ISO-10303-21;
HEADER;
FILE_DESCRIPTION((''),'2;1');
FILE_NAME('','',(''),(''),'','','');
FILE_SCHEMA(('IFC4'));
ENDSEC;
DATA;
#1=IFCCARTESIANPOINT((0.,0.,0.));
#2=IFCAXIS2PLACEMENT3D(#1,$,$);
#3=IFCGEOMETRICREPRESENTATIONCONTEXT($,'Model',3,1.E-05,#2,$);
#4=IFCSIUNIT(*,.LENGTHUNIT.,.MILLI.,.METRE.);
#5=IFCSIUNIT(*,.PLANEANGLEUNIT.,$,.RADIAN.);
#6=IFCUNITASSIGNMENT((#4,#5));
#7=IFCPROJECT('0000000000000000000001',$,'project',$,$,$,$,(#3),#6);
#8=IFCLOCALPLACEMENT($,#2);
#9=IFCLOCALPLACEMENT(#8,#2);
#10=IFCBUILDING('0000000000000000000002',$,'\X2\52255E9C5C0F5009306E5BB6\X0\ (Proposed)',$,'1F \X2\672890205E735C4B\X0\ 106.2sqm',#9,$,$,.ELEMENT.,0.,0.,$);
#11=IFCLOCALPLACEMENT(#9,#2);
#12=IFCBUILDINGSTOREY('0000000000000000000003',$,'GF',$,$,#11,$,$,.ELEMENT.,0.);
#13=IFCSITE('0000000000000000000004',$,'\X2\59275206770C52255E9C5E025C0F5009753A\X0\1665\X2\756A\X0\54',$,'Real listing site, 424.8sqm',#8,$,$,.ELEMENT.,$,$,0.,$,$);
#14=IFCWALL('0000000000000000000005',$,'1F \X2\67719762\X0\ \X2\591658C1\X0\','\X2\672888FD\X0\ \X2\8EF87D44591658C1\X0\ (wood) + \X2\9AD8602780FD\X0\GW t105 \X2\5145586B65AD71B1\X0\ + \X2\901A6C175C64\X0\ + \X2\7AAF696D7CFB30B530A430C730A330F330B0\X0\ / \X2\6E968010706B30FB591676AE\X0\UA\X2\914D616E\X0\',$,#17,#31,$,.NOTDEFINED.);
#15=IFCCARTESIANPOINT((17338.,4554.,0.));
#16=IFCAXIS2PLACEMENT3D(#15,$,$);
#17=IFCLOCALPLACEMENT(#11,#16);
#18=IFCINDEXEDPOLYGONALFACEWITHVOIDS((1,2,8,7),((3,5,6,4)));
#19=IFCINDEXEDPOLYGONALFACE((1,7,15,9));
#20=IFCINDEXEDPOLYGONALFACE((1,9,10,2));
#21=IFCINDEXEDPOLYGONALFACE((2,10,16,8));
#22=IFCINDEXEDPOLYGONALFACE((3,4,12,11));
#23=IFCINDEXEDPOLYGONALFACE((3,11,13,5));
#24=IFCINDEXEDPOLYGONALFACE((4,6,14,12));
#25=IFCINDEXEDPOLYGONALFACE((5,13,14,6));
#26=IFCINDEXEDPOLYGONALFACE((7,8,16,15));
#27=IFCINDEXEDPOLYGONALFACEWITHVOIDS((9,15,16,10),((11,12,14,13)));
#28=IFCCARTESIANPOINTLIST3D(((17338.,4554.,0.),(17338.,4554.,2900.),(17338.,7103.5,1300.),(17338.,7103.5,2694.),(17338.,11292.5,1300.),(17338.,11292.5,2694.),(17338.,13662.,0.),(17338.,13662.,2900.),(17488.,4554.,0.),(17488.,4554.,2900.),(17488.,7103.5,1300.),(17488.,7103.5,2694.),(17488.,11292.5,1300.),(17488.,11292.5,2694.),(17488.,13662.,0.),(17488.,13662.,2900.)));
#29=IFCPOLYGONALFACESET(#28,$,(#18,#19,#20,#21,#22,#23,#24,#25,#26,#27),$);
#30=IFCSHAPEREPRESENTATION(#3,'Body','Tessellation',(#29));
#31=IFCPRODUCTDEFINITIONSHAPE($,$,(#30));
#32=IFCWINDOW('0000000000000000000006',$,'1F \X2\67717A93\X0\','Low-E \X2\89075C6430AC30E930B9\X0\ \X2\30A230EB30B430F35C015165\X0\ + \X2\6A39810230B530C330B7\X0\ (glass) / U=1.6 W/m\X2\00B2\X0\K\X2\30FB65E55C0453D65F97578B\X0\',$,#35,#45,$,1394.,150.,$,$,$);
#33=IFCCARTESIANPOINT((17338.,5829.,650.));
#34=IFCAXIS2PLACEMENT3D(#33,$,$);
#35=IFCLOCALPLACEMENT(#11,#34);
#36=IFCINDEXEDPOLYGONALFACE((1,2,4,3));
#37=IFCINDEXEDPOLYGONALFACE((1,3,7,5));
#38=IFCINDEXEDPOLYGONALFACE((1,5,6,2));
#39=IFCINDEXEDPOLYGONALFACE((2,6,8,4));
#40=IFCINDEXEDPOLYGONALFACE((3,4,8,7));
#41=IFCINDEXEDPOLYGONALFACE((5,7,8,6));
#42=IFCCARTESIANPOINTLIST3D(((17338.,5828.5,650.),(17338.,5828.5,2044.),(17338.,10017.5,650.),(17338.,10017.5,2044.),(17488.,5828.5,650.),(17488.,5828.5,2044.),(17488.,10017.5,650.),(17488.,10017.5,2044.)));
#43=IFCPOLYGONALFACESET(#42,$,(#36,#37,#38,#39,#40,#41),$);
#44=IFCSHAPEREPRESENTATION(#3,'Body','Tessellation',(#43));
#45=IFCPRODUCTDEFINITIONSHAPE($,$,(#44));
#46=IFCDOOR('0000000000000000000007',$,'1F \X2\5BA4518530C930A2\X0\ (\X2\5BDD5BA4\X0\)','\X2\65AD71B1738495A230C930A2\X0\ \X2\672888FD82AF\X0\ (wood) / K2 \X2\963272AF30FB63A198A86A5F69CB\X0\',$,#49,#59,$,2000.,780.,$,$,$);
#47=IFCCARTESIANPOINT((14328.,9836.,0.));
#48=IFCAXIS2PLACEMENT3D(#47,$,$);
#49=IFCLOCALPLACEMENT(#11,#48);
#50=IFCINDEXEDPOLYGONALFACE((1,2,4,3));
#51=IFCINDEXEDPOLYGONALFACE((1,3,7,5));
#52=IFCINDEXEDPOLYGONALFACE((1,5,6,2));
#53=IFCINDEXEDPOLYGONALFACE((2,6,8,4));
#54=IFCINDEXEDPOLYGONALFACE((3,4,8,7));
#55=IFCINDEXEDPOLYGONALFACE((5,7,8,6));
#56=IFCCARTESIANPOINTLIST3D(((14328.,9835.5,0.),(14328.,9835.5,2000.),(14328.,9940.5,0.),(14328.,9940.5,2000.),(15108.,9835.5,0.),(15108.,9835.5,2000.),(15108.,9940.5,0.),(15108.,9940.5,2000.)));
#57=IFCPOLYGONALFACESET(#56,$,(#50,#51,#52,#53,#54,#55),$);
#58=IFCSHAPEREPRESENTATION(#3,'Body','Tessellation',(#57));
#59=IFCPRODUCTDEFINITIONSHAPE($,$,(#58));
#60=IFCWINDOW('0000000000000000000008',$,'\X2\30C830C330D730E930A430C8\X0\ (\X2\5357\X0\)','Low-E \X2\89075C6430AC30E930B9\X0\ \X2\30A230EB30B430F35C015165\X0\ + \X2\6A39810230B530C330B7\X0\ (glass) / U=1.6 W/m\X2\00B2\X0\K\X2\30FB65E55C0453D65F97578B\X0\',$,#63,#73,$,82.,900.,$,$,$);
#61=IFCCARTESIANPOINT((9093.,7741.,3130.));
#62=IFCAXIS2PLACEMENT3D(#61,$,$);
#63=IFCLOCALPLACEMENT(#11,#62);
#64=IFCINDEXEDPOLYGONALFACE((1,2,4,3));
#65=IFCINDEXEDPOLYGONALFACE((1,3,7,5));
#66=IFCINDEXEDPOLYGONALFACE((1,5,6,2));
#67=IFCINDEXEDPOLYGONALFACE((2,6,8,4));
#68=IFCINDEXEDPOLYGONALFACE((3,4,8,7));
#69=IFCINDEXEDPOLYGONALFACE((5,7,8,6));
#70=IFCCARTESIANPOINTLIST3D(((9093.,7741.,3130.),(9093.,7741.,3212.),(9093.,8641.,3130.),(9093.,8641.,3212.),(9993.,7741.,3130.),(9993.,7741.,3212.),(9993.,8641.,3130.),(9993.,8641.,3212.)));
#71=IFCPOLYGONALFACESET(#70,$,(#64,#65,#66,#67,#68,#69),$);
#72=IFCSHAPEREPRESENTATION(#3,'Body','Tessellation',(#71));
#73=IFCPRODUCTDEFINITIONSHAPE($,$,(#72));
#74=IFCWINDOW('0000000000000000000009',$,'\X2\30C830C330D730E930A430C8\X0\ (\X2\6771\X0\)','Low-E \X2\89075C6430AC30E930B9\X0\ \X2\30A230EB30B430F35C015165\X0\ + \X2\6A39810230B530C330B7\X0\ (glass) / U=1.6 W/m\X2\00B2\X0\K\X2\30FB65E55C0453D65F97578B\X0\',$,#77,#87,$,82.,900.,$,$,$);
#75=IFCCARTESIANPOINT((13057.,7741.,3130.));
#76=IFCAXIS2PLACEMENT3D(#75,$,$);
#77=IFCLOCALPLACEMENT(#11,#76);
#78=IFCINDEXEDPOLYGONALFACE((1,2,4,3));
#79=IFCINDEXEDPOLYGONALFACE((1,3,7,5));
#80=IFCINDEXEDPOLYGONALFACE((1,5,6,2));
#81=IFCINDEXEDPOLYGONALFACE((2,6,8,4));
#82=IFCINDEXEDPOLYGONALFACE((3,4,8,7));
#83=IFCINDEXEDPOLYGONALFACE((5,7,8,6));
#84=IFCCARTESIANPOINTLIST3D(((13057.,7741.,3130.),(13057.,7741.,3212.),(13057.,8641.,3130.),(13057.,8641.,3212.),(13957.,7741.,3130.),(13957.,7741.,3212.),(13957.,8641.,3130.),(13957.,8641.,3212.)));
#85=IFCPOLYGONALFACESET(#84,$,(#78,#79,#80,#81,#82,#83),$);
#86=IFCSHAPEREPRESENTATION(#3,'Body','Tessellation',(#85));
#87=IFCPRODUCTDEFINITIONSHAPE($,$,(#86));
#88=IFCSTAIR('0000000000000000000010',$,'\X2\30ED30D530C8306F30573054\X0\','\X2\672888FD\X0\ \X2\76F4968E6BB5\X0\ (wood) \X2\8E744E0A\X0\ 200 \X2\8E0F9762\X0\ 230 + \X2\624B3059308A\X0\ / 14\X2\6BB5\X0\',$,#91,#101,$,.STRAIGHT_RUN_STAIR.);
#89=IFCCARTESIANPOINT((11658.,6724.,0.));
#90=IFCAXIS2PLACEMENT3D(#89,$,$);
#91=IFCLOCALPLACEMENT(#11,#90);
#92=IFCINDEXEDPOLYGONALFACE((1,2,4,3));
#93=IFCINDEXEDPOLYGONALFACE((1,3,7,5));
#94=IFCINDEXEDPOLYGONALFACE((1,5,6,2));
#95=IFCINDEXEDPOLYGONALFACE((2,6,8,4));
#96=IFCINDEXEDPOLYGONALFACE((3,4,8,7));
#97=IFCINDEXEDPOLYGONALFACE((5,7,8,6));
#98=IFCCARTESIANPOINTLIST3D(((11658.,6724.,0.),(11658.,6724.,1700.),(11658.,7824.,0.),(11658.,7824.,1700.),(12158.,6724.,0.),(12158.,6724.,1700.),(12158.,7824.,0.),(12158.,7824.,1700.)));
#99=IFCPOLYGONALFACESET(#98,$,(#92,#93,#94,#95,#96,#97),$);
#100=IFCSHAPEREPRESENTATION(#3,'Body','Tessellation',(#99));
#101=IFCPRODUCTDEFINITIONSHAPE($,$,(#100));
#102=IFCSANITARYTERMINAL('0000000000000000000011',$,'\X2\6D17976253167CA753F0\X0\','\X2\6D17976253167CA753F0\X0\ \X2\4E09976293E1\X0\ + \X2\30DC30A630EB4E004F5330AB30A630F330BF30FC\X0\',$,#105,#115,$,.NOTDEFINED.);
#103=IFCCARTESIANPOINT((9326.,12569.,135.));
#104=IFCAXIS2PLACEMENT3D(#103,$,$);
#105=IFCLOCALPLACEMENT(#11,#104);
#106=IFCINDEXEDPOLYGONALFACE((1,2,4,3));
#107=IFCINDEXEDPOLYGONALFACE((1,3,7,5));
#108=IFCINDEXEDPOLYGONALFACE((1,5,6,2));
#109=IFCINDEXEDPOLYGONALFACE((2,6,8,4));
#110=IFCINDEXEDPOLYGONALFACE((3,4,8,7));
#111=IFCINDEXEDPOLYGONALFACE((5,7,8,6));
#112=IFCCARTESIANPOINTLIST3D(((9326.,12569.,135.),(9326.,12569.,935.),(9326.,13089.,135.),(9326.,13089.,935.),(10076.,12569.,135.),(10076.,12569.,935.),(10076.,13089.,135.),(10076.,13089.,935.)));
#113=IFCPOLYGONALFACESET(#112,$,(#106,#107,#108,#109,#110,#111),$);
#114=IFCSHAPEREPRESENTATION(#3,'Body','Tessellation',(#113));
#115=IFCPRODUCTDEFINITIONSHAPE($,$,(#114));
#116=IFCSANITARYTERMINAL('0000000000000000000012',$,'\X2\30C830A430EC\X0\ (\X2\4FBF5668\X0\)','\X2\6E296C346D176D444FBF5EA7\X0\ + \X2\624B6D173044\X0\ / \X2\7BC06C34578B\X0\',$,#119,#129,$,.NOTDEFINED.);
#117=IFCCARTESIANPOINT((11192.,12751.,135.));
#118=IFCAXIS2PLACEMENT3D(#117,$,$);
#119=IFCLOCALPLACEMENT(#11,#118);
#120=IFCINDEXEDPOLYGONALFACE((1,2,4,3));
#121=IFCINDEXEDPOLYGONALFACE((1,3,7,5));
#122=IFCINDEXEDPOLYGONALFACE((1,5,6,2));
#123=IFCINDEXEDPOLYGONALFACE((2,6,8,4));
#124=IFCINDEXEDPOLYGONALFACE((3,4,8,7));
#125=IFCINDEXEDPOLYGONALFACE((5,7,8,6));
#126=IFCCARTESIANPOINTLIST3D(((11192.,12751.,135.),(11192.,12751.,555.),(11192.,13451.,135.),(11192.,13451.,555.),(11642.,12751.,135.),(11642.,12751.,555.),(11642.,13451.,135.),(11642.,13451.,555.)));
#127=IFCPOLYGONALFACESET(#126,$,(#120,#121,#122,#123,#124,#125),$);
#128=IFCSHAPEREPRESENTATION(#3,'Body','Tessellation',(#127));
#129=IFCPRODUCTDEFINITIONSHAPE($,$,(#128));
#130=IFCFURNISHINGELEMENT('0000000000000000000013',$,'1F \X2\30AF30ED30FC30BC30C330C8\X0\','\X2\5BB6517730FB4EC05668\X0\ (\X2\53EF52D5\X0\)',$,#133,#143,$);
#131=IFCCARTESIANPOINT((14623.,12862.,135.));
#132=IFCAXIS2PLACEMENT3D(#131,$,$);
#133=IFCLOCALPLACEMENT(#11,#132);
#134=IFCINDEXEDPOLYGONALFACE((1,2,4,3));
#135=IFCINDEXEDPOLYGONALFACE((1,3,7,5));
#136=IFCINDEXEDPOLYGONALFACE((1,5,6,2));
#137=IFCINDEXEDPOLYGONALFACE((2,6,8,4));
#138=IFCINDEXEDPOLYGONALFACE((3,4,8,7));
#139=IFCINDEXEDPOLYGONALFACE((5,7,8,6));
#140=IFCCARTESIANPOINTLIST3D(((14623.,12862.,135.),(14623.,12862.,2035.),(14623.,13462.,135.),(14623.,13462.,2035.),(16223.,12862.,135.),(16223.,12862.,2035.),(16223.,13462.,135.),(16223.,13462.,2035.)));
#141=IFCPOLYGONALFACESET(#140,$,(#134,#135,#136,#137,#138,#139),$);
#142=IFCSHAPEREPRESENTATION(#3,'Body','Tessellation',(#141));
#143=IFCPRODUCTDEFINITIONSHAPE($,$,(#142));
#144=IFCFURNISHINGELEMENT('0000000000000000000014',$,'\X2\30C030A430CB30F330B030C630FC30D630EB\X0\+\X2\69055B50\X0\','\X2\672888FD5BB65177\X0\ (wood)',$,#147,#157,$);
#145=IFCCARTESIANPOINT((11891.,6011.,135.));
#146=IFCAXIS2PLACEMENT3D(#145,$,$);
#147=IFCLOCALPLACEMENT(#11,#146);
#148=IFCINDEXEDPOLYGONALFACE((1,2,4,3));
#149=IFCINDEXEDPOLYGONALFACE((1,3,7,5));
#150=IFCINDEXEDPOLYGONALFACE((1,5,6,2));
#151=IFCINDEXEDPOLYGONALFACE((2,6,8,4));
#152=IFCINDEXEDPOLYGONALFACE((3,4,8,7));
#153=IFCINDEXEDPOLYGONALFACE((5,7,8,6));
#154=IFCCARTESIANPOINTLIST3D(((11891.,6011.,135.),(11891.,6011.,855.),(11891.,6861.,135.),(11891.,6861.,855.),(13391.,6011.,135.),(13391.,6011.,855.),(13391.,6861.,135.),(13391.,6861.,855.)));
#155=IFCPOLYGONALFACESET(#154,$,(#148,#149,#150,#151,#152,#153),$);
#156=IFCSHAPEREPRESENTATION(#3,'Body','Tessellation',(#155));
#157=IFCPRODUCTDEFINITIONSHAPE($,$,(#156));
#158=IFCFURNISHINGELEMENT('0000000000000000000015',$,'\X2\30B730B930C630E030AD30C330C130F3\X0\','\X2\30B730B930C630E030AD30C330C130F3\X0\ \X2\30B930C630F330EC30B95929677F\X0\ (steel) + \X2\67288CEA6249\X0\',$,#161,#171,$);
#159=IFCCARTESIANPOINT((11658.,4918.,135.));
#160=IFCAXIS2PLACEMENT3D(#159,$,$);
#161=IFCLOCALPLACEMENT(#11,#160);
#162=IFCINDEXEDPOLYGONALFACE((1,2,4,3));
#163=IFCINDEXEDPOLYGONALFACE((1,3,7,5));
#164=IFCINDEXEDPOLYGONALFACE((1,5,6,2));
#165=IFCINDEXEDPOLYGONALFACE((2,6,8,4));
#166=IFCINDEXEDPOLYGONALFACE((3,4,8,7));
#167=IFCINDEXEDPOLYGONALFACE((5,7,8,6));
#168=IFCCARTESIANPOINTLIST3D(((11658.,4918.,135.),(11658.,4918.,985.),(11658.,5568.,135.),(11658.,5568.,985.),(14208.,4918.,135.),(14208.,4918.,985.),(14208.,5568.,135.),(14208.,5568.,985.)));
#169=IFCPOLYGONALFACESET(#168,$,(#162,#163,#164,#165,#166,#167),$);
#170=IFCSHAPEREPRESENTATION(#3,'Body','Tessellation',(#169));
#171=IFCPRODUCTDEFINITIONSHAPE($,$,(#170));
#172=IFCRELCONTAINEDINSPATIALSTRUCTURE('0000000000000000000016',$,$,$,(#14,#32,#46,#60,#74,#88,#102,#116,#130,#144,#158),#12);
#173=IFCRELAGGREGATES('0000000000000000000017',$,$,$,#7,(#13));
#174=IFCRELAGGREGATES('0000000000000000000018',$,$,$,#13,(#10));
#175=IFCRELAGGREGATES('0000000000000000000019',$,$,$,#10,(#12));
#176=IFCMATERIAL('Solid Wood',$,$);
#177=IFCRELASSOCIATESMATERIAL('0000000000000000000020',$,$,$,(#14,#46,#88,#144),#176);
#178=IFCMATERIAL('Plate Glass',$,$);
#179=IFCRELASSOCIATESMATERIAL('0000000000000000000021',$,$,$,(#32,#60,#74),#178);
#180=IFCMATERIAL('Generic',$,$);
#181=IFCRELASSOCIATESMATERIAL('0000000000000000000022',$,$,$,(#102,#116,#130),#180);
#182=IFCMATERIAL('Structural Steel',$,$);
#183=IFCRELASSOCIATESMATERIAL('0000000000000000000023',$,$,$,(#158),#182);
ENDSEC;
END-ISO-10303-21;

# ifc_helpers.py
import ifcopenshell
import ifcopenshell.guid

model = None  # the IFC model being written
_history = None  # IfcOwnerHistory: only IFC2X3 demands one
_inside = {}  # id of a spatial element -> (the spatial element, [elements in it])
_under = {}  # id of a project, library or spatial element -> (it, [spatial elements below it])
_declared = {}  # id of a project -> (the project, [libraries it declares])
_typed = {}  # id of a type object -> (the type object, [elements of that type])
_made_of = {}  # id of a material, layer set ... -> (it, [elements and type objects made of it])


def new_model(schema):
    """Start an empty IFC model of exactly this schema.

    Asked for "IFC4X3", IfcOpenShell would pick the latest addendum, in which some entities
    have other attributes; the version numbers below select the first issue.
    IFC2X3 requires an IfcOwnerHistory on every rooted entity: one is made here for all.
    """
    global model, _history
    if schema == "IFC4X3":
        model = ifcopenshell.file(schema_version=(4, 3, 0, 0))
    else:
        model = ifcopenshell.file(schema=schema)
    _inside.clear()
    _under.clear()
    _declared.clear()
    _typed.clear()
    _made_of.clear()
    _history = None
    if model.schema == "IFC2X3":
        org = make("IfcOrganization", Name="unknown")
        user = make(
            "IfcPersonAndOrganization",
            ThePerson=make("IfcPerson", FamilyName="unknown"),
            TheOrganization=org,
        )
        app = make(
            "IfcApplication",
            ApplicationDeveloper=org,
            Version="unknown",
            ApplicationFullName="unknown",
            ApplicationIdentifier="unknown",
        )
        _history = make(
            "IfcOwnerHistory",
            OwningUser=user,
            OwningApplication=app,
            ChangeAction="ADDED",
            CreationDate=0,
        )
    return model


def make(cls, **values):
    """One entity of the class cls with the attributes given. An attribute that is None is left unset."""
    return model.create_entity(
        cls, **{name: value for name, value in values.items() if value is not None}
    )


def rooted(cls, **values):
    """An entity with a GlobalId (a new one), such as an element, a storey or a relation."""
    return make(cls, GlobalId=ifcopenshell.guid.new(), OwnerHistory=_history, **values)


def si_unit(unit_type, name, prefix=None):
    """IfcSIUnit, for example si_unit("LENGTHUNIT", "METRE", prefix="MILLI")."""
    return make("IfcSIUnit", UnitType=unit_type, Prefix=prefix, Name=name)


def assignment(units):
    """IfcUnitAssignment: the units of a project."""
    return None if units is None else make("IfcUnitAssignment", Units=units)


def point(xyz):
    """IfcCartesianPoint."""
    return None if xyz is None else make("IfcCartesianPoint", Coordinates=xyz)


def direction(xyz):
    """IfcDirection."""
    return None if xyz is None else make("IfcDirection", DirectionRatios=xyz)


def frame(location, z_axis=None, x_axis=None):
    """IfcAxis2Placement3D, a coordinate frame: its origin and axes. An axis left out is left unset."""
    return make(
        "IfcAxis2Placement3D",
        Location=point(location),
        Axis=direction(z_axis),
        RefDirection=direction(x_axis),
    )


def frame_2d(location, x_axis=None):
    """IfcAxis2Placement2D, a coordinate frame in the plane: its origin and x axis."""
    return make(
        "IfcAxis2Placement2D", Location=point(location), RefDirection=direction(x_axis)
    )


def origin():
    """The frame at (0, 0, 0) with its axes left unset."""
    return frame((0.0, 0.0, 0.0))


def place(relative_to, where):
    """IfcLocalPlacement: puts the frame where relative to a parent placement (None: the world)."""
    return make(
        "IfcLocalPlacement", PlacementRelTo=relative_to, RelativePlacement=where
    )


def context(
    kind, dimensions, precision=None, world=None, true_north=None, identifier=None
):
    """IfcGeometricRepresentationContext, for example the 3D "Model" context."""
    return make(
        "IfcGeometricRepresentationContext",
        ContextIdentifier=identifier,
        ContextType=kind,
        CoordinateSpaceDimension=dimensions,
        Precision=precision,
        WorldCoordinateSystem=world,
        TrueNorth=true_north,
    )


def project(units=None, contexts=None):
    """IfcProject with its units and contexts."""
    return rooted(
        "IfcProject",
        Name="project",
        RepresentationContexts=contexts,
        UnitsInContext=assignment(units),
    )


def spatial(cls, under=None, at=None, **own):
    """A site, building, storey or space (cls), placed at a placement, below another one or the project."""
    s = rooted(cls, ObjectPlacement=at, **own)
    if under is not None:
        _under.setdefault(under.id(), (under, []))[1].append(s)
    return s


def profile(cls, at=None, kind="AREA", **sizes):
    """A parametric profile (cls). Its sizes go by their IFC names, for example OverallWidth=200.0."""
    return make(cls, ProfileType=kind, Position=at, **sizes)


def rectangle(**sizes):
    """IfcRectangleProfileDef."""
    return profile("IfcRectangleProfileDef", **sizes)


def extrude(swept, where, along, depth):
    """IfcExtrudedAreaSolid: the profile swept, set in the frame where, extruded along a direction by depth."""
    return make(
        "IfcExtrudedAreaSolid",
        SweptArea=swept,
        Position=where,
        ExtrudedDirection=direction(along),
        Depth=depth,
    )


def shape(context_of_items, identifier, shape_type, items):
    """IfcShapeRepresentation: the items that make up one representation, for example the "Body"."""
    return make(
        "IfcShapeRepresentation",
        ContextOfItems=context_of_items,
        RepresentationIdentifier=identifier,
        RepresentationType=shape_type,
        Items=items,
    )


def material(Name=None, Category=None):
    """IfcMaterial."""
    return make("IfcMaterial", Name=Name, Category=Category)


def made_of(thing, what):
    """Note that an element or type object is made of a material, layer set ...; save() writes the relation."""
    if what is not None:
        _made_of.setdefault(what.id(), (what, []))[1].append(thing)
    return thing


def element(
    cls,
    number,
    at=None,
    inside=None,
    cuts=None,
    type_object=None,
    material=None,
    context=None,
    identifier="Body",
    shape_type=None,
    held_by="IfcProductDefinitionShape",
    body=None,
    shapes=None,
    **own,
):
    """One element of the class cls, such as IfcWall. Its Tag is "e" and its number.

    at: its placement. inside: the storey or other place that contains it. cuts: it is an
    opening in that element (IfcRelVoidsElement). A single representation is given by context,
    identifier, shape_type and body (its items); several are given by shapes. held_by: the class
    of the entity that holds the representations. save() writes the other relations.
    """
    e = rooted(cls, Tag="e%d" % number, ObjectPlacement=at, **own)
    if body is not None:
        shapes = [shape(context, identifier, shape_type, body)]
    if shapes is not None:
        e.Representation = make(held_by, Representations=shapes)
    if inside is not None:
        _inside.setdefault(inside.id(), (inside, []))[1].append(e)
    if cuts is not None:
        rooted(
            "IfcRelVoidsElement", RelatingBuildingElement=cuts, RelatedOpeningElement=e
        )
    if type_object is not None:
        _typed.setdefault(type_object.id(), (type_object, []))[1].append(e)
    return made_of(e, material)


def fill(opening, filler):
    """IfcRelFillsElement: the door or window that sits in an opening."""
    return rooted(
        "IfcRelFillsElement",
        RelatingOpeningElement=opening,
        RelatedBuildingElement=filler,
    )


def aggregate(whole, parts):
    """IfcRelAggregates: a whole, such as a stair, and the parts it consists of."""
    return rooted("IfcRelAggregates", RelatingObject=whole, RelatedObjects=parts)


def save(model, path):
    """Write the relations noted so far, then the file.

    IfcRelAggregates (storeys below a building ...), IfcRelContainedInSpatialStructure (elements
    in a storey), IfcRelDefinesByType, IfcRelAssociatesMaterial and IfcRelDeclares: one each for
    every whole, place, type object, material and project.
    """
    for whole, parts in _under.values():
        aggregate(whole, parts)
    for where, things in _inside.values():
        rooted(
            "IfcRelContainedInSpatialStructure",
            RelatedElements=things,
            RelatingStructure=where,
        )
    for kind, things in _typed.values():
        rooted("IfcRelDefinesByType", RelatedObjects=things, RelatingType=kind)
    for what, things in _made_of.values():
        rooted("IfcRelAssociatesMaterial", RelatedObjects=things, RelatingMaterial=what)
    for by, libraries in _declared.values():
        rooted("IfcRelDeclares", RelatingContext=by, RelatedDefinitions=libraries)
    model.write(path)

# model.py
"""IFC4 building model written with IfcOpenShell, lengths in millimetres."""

from ifc_helpers import new_model, si_unit, frame, frame_2d, origin, place, context, project, spatial, rectangle, extrude, material, element, fill, save


model = new_model("IFC4")

# Units and contexts
model_context = context("Model", 3, precision=1e-05, world=origin())
ifc_project = project(units=[si_unit("LENGTHUNIT", "METRE", prefix="MILLI"), si_unit("PLANEANGLEUNIT", "RADIAN")], contexts=[model_context])

# Site, building, storey
site_placement = place(None, origin())
site = spatial("IfcSite", under=ifc_project, at=site_placement, Name="大分県別府市小倉町1665番54", ObjectType="Real listing site, 424.8sqm", CompositionType="ELEMENT", RefElevation=0.0)
building_placement = place(site_placement, origin())
building = spatial("IfcBuilding", under=site, at=building_placement, Name="別府小倉の家 (Proposed)", ObjectType="1F 木造平屋 106.2sqm", CompositionType="ELEMENT", ElevationOfRefHeight=0.0, ElevationOfTerrain=0.0)
storey_placement = place(building_placement, origin())
storey = spatial("IfcBuildingStorey", under=building, at=storey_placement, Name="GF", CompositionType="ELEMENT", Elevation=0.0)

# Wall, opening, window
ifc_material_1 = material(Name="Solid Wood")
wall_1_placement = place(storey_placement, frame((17338.0, 4554.0, 0.0)))
wall_1 = element("IfcWall", 1, at=wall_1_placement, inside=storey, material=ifc_material_1, Name="1F 東面 外壁", Description="木製 軸組外壁 (wood) + 高性能GW t105 充填断熱 + 通気層 + 窯業系サイディング / 準耐火・外皮UA配慮", PredefinedType="NOTDEFINED", context=model_context, shape_type="SweptSolid", body=[
    extrude(rectangle(XDim=150.0, YDim=9108.0, at=frame_2d((75.0, 4554.0))), frame((17338.0, 4554.0, 0.0)), (0.0, 0.0, 1.0), 2900.0),
])
opening_placement = place(storey_placement, frame((17338.0, 5829.0, 650.0)))
opening = element("IfcOpeningElement", 2, at=opening_placement, cuts=wall_1, PredefinedType="NOTDEFINED", context=model_context, shape_type="SweptSolid", body=[
    extrude(rectangle(XDim=150.0, YDim=4189.0, at=frame_2d((75.0, 2094.0))), frame((17338.0, 5829.0, 650.0)), (0.0, 0.0, 1.0), 1394.0),
])
ifc_material_2 = material(Name="Plate Glass")
window_1_placement = place(storey_placement, frame((17338.0, 5829.0, 650.0)))
window_1 = element("IfcWindow", 3, at=window_1_placement, inside=storey, material=ifc_material_2, Name="1F 東窓", Description="Low-E 複層ガラス アルゴン封入 + 樹脂サッシ (glass) / U=1.6 W/m²K・日射取得型", OverallHeight=1394.0, OverallWidth=150.0, context=model_context, shape_type="SweptSolid", body=[
    extrude(rectangle(XDim=150.0, YDim=4189.0, at=frame_2d((75.0, 2094.0))), frame((17338.0, 5829.0, 650.0)), (0.0, 0.0, 1.0), 1394.0),
])
fill(opening, window_1)

# Door
door_placement = place(storey_placement, frame((14328.0, 9836.0, 0.0)))
element("IfcDoor", 4, at=door_placement, inside=storey, material=ifc_material_1, Name="1F 室内ドア (寝室)", Description="断熱玄関ドア 木製芯 (wood) / K2 防犯・採風機構", OverallHeight=2000.0, OverallWidth=780.0, context=model_context, shape_type="SweptSolid", body=[
    extrude(rectangle(XDim=780.0, YDim=105.0, at=frame_2d((390.0, 52.0))), frame((14328.0, 9836.0, 0.0)), (0.0, 0.0, 1.0), 2000.0),
])

# Windows
window_2_placement = place(storey_placement, frame((9093.0, 7741.0, 3130.0)))
element("IfcWindow", 5, at=window_2_placement, inside=storey, material=ifc_material_2, Name="トップライト (南)", Description="Low-E 複層ガラス アルゴン封入 + 樹脂サッシ (glass) / U=1.6 W/m²K・日射取得型", OverallHeight=82.0, OverallWidth=900.0, context=model_context, shape_type="SweptSolid", body=[
    extrude(rectangle(XDim=900.0, YDim=900.0, at=frame_2d((450.0, 450.0))), frame((9093.0, 7741.0, 3130.0)), (0.0, 0.0, 1.0), 82.0),
])
window_3_placement = place(storey_placement, frame((13057.0, 7741.0, 3130.0)))
element("IfcWindow", 6, at=window_3_placement, inside=storey, material=ifc_material_2, Name="トップライト (東)", Description="Low-E 複層ガラス アルゴン封入 + 樹脂サッシ (glass) / U=1.6 W/m²K・日射取得型", OverallHeight=82.0, OverallWidth=900.0, context=model_context, shape_type="SweptSolid", body=[
    extrude(rectangle(XDim=900.0, YDim=900.0, at=frame_2d((450.0, 450.0))), frame((13057.0, 7741.0, 3130.0)), (0.0, 0.0, 1.0), 82.0),
])

# Stair
stair_placement = place(storey_placement, frame((11658.0, 6724.0, 0.0)))
element("IfcStair", 7, at=stair_placement, inside=storey, material=ifc_material_1, Name="ロフトはしご", Description="木製 直階段 (wood) 蹴上 200 踏面 230 + 手すり / 14段", PredefinedType="STRAIGHT_RUN_STAIR", context=model_context, shape_type="SweptSolid", body=[
    extrude(rectangle(XDim=500.0, YDim=1100.0, at=frame_2d((250.0, 550.0))), frame((11658.0, 6724.0, 0.0)), (0.0, 0.0, 1.0), 1700.0),
])

# Sanitary terminals
ifc_material_3 = material(Name="Generic")
sanitary_terminal_1_placement = place(storey_placement, frame((9326.0, 12569.0, 135.0)))
element("IfcSanitaryTerminal", 8, at=sanitary_terminal_1_placement, inside=storey, material=ifc_material_3, Name="洗面化粧台", Description="洗面化粧台 三面鏡 + ボウル一体カウンター", PredefinedType="NOTDEFINED", context=model_context, shape_type="SweptSolid", body=[
    extrude(rectangle(XDim=750.0, YDim=520.0, at=frame_2d((375.0, 260.0))), frame((9326.0, 12569.0, 135.0)), (0.0, 0.0, 1.0), 800.0),
])
sanitary_terminal_2_placement = place(storey_placement, frame((11192.0, 12751.0, 135.0)))
element("IfcSanitaryTerminal", 9, at=sanitary_terminal_2_placement, inside=storey, material=ifc_material_3, Name="トイレ (便器)", Description="温水洗浄便座 + 手洗い / 節水型", PredefinedType="NOTDEFINED", context=model_context, shape_type="SweptSolid", body=[
    extrude(rectangle(XDim=450.0, YDim=700.0, at=frame_2d((225.0, 350.0))), frame((11192.0, 12751.0, 135.0)), (0.0, 0.0, 1.0), 420.0),
])

# Furnishing elements
furnishing_1_placement = place(storey_placement, frame((14623.0, 12862.0, 135.0)))
element("IfcFurnishingElement", 10, at=furnishing_1_placement, inside=storey, material=ifc_material_3, Name="1F クローゼット", Description="家具・什器 (可動)", context=model_context, shape_type="SweptSolid", body=[
    extrude(rectangle(XDim=1600.0, YDim=600.0, at=frame_2d((800.0, 300.0))), frame((14623.0, 12862.0, 135.0)), (0.0, 0.0, 1.0), 1900.0),
])
furnishing_2_placement = place(storey_placement, frame((11891.0, 6011.0, 135.0)))
element("IfcFurnishingElement", 11, at=furnishing_2_placement, inside=storey, material=ifc_material_1, Name="ダイニングテーブル+椅子", Description="木製家具 (wood)", context=model_context, shape_type="SweptSolid", body=[
    extrude(rectangle(XDim=1500.0, YDim=850.0, at=frame_2d((750.0, 425.0))), frame((11891.0, 6011.0, 135.0)), (0.0, 0.0, 1.0), 720.0),
])
ifc_material_4 = material(Name="Structural Steel")
furnishing_3_placement = place(storey_placement, frame((11658.0, 4918.0, 135.0)))
element("IfcFurnishingElement", 12, at=furnishing_3_placement, inside=storey, material=ifc_material_4, Name="システムキッチン", Description="システムキッチン ステンレス天板 (steel) + 木質扉", context=model_context, shape_type="SweptSolid", body=[
    extrude(rectangle(XDim=2550.0, YDim=650.0, at=frame_2d((1275.0, 325.0))), frame((11658.0, 4918.0, 135.0)), (0.0, 0.0, 1.0), 850.0),
])

save(model, "model.ifc")
